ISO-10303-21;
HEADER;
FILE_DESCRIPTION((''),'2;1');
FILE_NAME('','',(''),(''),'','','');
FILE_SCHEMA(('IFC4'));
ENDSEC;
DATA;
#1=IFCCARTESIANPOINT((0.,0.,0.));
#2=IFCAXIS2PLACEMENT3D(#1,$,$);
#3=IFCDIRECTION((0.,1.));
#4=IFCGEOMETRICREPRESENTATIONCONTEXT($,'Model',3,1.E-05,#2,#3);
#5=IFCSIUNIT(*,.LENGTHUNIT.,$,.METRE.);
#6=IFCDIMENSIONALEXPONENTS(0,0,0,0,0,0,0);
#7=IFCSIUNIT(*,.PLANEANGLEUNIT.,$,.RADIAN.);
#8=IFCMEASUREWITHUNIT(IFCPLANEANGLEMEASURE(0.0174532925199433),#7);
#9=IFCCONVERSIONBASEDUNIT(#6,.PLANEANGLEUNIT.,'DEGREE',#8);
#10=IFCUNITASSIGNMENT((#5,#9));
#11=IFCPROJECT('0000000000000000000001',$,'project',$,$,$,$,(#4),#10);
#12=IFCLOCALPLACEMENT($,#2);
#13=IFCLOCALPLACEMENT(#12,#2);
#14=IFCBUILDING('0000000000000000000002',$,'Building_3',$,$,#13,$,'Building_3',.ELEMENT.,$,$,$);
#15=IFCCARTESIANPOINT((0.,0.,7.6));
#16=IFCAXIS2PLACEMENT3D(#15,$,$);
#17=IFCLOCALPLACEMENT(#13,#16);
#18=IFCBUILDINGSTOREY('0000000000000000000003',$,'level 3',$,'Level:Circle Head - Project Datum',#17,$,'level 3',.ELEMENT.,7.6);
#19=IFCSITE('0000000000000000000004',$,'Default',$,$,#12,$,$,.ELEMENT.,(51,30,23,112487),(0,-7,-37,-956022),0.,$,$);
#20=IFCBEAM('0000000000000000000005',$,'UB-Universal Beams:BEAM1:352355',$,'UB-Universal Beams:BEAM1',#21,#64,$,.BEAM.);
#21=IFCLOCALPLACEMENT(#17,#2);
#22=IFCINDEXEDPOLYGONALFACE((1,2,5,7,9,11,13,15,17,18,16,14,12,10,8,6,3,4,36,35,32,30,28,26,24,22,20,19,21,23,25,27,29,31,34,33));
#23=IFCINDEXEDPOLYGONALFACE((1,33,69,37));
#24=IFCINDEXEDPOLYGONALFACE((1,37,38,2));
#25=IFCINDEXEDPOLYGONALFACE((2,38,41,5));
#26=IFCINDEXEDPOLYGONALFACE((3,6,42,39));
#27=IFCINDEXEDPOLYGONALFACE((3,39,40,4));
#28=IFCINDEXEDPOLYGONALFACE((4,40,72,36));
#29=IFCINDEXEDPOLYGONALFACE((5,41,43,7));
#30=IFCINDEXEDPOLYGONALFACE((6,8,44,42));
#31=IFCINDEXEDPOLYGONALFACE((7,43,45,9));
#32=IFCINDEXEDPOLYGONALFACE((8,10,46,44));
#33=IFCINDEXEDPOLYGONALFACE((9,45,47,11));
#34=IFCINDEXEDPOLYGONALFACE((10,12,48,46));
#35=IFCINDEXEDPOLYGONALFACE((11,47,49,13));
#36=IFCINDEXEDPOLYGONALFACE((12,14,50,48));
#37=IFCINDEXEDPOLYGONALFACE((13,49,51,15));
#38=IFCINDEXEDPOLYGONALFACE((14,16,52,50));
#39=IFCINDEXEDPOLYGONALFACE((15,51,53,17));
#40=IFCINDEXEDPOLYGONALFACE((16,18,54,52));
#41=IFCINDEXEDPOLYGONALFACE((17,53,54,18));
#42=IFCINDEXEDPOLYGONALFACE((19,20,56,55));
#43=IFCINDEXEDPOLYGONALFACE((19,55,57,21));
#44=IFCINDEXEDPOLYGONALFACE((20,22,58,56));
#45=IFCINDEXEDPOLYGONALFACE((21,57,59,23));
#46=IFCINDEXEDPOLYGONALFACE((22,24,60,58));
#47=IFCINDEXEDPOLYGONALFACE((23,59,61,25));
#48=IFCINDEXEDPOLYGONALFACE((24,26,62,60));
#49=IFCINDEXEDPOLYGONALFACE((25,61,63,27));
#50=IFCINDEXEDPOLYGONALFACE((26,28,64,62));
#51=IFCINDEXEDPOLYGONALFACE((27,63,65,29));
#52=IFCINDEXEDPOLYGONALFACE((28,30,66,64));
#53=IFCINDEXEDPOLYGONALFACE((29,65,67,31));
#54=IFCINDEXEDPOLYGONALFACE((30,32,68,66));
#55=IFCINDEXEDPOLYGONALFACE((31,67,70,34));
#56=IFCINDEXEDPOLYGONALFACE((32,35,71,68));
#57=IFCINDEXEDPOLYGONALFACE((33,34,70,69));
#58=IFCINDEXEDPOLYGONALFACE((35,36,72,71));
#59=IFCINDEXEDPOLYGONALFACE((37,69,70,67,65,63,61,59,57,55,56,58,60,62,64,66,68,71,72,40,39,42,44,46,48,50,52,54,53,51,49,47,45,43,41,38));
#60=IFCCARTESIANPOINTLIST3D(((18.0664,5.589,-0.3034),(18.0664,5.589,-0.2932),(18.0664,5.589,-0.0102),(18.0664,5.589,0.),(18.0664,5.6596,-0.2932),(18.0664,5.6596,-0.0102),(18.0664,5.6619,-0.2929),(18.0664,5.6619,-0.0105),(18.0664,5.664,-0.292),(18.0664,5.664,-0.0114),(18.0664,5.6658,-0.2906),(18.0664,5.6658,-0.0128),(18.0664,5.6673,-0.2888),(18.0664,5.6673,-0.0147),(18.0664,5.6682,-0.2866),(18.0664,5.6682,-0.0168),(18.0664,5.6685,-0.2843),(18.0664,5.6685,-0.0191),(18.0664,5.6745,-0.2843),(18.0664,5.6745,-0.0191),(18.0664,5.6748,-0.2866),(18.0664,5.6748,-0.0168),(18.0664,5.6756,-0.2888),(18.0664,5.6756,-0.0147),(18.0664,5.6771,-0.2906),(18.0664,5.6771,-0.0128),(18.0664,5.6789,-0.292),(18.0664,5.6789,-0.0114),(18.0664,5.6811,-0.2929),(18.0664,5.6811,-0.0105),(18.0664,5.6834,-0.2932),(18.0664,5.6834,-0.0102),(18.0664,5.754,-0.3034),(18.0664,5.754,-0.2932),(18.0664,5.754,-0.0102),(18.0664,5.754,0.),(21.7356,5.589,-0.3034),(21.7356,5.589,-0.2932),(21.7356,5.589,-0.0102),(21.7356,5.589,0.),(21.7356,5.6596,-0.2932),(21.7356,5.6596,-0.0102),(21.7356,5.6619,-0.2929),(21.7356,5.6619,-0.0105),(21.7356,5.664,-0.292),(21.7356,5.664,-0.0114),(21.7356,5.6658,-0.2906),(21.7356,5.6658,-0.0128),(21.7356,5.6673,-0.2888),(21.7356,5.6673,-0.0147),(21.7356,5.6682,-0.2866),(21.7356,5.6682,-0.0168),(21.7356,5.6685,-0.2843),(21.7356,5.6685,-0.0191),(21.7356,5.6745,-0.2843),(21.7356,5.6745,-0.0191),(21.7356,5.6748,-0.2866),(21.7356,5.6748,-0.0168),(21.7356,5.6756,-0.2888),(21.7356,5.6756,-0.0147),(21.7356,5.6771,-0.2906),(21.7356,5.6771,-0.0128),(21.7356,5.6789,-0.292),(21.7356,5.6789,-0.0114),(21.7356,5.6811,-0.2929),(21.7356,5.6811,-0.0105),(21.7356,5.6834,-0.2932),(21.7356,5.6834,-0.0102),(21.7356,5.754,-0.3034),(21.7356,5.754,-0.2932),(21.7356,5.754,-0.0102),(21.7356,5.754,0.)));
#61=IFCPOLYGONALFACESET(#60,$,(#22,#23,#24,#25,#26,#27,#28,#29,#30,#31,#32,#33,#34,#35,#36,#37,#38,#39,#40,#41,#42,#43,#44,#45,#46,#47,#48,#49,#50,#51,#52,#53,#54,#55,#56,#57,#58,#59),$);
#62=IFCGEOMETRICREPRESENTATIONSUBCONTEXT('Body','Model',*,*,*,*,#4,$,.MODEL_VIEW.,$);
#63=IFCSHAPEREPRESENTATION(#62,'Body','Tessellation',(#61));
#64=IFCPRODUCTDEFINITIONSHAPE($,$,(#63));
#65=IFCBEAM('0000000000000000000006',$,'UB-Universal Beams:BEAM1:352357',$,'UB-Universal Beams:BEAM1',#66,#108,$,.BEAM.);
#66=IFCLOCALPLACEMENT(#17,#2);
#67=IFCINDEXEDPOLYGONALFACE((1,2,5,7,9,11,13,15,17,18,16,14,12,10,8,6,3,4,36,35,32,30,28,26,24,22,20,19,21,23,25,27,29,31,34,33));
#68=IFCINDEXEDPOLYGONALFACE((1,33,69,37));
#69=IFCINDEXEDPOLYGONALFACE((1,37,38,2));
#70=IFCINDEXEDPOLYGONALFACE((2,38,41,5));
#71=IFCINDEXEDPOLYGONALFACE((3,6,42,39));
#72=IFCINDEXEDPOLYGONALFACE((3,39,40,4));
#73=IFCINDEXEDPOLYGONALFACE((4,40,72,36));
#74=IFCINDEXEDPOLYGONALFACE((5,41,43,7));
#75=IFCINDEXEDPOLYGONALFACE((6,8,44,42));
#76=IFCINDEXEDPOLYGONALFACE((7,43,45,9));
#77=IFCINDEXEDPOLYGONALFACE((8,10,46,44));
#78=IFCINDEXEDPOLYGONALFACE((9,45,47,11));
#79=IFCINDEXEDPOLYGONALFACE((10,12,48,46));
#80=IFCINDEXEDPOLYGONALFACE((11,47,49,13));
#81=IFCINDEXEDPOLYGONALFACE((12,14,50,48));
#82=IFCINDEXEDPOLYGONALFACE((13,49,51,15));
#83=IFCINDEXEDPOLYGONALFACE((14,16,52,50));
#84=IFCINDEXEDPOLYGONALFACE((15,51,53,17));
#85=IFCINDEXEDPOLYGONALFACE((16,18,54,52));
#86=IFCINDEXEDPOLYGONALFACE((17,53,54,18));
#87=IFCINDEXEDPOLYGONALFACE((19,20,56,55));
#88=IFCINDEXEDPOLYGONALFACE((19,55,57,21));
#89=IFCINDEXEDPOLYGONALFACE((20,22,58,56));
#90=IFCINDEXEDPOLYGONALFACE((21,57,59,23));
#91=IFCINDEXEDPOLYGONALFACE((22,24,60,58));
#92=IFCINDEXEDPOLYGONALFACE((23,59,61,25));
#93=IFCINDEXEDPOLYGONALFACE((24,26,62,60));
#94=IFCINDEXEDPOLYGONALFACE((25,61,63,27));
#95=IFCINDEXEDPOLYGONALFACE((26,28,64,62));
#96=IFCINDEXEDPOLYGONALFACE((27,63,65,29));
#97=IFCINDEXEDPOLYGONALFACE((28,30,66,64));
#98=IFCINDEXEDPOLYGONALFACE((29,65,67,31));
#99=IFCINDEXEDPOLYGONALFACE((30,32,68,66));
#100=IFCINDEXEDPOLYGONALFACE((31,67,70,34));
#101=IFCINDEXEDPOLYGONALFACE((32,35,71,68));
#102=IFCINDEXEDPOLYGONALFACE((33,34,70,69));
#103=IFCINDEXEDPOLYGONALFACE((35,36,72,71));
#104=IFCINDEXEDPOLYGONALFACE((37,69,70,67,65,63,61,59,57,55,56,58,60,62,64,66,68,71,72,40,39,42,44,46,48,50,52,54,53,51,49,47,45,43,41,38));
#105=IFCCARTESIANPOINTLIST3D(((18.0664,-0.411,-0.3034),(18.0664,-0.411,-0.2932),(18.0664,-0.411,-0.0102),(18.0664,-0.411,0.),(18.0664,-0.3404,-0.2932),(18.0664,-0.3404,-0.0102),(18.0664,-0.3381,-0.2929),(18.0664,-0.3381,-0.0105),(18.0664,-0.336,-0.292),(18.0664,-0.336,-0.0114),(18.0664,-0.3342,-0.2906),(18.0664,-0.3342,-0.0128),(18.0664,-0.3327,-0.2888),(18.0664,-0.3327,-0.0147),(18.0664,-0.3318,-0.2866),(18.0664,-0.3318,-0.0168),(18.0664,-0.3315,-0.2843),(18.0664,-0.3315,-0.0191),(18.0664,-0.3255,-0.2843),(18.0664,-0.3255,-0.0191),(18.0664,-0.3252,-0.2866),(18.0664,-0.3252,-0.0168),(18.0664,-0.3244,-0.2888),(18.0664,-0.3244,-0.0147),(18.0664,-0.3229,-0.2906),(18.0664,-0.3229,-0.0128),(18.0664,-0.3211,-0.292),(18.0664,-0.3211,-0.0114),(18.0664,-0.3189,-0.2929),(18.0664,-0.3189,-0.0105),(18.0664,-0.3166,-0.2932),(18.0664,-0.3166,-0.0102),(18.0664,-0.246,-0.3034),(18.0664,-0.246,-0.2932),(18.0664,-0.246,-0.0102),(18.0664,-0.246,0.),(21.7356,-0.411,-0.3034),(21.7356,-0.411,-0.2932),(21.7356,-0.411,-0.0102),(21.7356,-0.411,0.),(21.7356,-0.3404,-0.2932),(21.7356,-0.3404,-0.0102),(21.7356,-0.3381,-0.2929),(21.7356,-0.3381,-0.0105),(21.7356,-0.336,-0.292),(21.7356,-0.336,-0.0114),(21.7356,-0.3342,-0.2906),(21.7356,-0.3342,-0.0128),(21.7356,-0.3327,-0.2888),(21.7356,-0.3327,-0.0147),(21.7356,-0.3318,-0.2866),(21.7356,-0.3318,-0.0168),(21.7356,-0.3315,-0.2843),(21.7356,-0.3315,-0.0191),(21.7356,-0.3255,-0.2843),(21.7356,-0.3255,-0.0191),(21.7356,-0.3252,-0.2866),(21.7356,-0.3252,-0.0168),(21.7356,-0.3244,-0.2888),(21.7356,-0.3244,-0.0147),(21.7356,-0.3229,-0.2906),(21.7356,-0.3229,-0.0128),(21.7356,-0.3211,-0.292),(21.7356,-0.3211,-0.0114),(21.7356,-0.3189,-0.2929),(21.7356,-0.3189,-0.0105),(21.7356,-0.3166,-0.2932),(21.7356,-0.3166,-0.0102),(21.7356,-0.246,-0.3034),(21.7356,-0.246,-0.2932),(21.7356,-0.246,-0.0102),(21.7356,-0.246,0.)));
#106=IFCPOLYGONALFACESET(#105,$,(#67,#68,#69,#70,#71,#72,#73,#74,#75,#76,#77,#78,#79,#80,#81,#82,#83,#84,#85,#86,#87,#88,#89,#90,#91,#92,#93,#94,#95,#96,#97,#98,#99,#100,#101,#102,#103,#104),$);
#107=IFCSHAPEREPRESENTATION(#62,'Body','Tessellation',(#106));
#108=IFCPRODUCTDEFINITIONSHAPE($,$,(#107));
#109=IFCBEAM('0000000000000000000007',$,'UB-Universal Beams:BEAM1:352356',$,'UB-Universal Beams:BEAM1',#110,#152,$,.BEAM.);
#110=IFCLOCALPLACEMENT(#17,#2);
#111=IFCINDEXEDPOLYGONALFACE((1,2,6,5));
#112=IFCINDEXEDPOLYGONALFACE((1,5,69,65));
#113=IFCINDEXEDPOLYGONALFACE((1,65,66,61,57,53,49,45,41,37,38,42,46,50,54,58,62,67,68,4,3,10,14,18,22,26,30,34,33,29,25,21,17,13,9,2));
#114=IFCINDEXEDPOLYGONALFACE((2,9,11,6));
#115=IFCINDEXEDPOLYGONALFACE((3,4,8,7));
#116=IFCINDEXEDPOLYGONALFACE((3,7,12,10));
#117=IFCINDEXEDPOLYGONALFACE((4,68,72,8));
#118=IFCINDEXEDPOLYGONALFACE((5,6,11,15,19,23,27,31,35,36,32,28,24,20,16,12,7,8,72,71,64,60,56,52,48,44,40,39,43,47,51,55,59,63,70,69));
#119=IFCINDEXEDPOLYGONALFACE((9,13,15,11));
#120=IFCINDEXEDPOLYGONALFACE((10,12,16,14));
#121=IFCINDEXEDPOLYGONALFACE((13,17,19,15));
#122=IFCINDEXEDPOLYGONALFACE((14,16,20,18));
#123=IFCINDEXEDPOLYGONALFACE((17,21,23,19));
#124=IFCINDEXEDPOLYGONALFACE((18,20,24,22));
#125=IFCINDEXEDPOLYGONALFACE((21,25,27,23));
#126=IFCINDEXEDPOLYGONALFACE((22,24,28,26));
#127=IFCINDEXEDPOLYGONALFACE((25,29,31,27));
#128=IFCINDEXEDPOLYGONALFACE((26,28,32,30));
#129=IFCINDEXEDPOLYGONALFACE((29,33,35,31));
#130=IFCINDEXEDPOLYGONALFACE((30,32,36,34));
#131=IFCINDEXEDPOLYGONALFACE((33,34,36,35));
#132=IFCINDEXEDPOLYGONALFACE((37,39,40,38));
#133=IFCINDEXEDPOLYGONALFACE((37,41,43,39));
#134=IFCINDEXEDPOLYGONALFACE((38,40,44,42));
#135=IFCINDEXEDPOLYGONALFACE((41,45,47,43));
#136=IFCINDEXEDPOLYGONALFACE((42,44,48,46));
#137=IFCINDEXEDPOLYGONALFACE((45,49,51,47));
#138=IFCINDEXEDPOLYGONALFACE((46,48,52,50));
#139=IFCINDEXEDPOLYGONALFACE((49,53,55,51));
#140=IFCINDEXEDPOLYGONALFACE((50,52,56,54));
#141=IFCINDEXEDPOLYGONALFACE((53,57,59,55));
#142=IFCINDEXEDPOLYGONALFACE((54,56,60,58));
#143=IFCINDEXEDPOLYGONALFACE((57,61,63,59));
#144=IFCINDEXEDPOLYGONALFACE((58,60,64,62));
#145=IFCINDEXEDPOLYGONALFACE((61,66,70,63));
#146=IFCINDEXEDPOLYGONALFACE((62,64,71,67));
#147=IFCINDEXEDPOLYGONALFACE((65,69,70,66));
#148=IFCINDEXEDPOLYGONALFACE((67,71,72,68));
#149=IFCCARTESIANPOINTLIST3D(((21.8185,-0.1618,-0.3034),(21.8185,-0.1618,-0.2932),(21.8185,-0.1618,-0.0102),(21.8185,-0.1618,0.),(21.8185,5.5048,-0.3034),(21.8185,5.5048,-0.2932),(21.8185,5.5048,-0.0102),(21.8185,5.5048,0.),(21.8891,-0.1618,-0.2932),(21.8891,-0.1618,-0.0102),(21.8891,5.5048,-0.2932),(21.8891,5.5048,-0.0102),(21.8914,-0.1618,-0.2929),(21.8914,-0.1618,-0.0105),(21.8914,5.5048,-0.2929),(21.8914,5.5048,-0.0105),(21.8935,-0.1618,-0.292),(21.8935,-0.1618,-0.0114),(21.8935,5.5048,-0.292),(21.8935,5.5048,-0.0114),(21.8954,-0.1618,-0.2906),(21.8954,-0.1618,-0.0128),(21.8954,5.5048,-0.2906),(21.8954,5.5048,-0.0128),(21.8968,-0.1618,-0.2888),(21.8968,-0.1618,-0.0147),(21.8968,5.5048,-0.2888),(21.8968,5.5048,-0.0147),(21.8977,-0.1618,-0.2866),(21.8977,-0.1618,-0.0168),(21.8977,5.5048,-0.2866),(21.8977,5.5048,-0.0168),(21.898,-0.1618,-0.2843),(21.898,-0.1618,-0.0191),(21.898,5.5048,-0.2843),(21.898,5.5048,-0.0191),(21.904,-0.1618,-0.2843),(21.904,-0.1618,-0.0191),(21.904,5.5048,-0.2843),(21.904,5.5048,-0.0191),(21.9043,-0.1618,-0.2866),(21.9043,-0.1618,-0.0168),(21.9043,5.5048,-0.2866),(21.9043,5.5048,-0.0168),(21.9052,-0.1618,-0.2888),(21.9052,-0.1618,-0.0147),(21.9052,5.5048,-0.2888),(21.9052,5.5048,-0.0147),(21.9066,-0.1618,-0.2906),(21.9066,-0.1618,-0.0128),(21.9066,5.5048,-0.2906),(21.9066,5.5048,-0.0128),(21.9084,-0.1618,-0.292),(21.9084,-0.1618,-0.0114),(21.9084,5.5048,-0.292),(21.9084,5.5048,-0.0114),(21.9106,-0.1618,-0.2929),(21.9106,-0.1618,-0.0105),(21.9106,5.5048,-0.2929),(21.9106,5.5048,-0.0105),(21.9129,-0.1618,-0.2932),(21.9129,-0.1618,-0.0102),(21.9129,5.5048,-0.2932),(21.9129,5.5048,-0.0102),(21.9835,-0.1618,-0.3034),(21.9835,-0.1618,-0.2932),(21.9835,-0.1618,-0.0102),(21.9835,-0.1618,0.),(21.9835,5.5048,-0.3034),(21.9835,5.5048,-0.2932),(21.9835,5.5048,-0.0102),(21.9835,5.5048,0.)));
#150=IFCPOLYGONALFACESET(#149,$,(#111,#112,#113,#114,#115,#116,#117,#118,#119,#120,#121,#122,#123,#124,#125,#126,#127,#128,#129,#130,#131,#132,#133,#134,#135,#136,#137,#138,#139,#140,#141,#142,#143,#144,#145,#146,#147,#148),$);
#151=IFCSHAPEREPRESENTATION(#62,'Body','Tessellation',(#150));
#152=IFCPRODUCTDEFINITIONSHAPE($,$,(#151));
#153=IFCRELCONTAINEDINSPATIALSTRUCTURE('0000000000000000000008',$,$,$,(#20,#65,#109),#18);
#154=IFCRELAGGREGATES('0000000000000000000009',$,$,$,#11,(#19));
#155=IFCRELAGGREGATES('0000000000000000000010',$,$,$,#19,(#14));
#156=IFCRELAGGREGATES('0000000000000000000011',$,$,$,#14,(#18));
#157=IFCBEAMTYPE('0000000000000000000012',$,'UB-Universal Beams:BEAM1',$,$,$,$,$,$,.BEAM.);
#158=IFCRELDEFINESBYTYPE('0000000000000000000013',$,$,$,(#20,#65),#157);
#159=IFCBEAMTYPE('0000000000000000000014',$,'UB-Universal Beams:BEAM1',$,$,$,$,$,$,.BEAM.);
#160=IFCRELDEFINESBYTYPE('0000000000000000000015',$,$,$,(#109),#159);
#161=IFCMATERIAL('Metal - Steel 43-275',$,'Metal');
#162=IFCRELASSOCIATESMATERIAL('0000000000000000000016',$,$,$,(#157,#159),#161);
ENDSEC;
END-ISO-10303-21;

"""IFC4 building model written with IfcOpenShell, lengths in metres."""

from ifc_helpers import new_model, entity, si_unit, converted_unit, direction, frame, frame_2d, origin, place, context, subcontext, project, spatial, polyline, circle_curve, parameter, trimmed, segment, composite_curve, outline, extrude, source, transform, mapped, material, material_profile, profile_set, type_object, type_shapes, element, save


model = new_model("IFC4")

# Units and contexts
model_context = context("Model", 3, precision=1e-05, world=origin(), true_north=direction((0.0, 1.0)))
body_context = subcontext(model_context, "Body", "Model", "MODEL_VIEW")
ifc_project = project(units=[si_unit("LENGTHUNIT", "METRE"), converted_unit("PLANEANGLEUNIT", "DEGREE", entity("IfcPlaneAngleMeasure", 0.0174532925199433), si_unit("PLANEANGLEUNIT", "RADIAN"), dimensions=[0, 0, 0, 0, 0, 0, 0])], contexts=[model_context])

# Site, building, storey
site_placement = place(None, origin())
site = spatial("IfcSite", under=ifc_project, at=site_placement, Name="Default", CompositionType="ELEMENT", RefLatitude=(51, 30, 23, 112487), RefLongitude=(0, -7, -37, -956022), RefElevation=0.0)
building_placement = place(site_placement, origin())
building = spatial("IfcBuilding", under=site, at=building_placement, Name="Building_3", LongName="Building_3", CompositionType="ELEMENT")
storey_placement = place(building_placement, frame((0.0, 0.0, 7.6)))
storey = spatial("IfcBuildingStorey", under=building, at=storey_placement, Name="level 3", ObjectType="Level:Circle Head - Project Datum", LongName="level 3", CompositionType="ELEMENT", Elevation=7.6)

# Beams
ifc_material_1 = material(Name="Metal - Steel 43-275", Category="Metal")
ifc_material_profile = material_profile(ifc_material_1, outline(composite_curve([segment(polyline([(-0.0825, -0.1415), (-0.0825, -0.1517)]), True, "CONTINUOUS"), segment(polyline([(-0.0825, -0.1517), (0.0825, -0.1517)]), True, "CONTINUOUS"), segment(polyline([(0.0825, -0.1517), (0.0825, -0.1415)]), True, "CONTINUOUS"), segment(polyline([(0.0825, -0.1415), (0.0119, -0.1415)]), True, "CONTINUOUS"), segment(trimmed(circle_curve(frame_2d((0.0119, -0.1326), x_axis=(1.0, 0.0)), 0.0089), [parameter(180.0)], [parameter(270.0)], True, "PARAMETER"), False, "CONTINUOUS"), segment(polyline([(0.003, -0.1326), (0.003, 0.1326)]), True, "CONTINUOUS"), segment(trimmed(circle_curve(frame_2d((0.0119, 0.1326), x_axis=(1.0, 0.0)), 0.0089), [parameter(90.0)], [parameter(180.0)], True, "PARAMETER"), False, "CONTINUOUS"), segment(polyline([(0.0119, 0.1415), (0.0825, 0.1415)]), True, "CONTINUOUS"), segment(polyline([(0.0825, 0.1415), (0.0825, 0.1517)]), True, "CONTINUOUS"), segment(polyline([(0.0825, 0.1517), (-0.0825, 0.1517)]), True, "CONTINUOUS"), segment(polyline([(-0.0825, 0.1517), (-0.0825, 0.1415)]), True, "CONTINUOUS"), segment(polyline([(-0.0825, 0.1415), (-0.0119, 0.1415)]), True, "CONTINUOUS"), segment(trimmed(circle_curve(frame_2d((-0.0119, 0.1326), x_axis=(1.0, 0.0)), 0.0089), [parameter(360.0)], [parameter(90.0)], True, "PARAMETER"), False, "CONTINUOUS"), segment(polyline([(-0.003, 0.1326), (-0.003, -0.1326)]), True, "CONTINUOUS"), segment(trimmed(circle_curve(frame_2d((-0.0119, -0.1326), x_axis=(1.0, 0.0)), 0.0089), [parameter(270.0)], [parameter(360.0)], True, "PARAMETER"), False, "CONTINUOUS"), segment(polyline([(-0.0119, -0.1415), (-0.0825, -0.1415)]), True, "CONTINUOUS")], self_intersect=False)), Name="BEAM1")
ifc_profile_set = profile_set([ifc_material_profile], Name="BEAM1")
beam_type_1 = type_object("IfcBeamType", Name="UB-Universal Beams:BEAM1", PredefinedType="BEAM", material=ifc_profile_set)
shared_shape_1 = source(origin(), body_context, "Body", "SweptSolid", [
    extrude(outline(composite_curve([segment(polyline([(-0.0825, -0.1415), (-0.0825, -0.1517)]), True, "CONTINUOUS"), segment(polyline([(-0.0825, -0.1517), (0.0825, -0.1517)]), True, "CONTINUOUS"), segment(polyline([(0.0825, -0.1517), (0.0825, -0.1415)]), True, "CONTINUOUS"), segment(polyline([(0.0825, -0.1415), (0.0119, -0.1415)]), True, "CONTINUOUS"), segment(trimmed(circle_curve(frame_2d((0.0119, -0.1326), x_axis=(0.0, -1.0)), 0.0089), [parameter(270.0)], [parameter(360.0)], True, "PARAMETER"), False, "CONTINUOUS"), segment(polyline([(0.003, -0.1326), (0.003, 0.1326)]), True, "CONTINUOUS"), segment(trimmed(circle_curve(frame_2d((0.0119, 0.1326), x_axis=(-1.0, 0.0)), 0.0089), [parameter(270.0)], [parameter(360.0)], True, "PARAMETER"), False, "CONTINUOUS"), segment(polyline([(0.0119, 0.1415), (0.0825, 0.1415)]), True, "CONTINUOUS"), segment(polyline([(0.0825, 0.1415), (0.0825, 0.1517)]), True, "CONTINUOUS"), segment(polyline([(0.0825, 0.1517), (-0.0825, 0.1517)]), True, "CONTINUOUS"), segment(polyline([(-0.0825, 0.1517), (-0.0825, 0.1415)]), True, "CONTINUOUS"), segment(polyline([(-0.0825, 0.1415), (-0.0119, 0.1415)]), True, "CONTINUOUS"), segment(trimmed(circle_curve(frame_2d((-0.0119, 0.1326), x_axis=(0.0, 1.0)), 0.0089), [parameter(270.0)], [parameter(360.0)], True, "PARAMETER"), False, "CONTINUOUS"), segment(polyline([(-0.003, 0.1326), (-0.003, -0.1326)]), True, "CONTINUOUS"), segment(trimmed(circle_curve(frame_2d((-0.0119, -0.1326), x_axis=(1.0, 0.0)), 0.0089), [parameter(270.0)], [parameter(0.0)], True, "PARAMETER"), False, "CONTINUOUS"), segment(polyline([(-0.0119, -0.1415), (-0.0825, -0.1415)]), True, "CONTINUOUS")], self_intersect=False)), frame((-1.8346, 0.0, 0.0), z_axis=(-1.0, 0.0, 0.0), x_axis=(0.0, -1.0, 0.0)), (0.0, 0.0, -1.0), 3.6692),
])
type_shapes(beam_type_1, [shared_shape_1])
for number, where, name in (
    (1, (19.901, 5.6715, -0.1517), "UB-Universal Beams:BEAM1:352355"),
    (2, (19.901, -0.3285, -0.1517), "UB-Universal Beams:BEAM1:352357"),
):
    element("IfcBeam", number, at=place(storey_placement, frame(where)), inside=storey, type_object=beam_type_1, Name=name, ObjectType="UB-Universal Beams:BEAM1", PredefinedType="BEAM", context=body_context, shape_type="MappedRepresentation", body=[
        mapped(shared_shape_1, transform((0.0, 0.0, 0.0), scale=1.0)),
    ])
beam_type_2 = type_object("IfcBeamType", Name="UB-Universal Beams:BEAM1", PredefinedType="BEAM", material=ifc_profile_set)
shared_shape_2 = source(origin(), body_context, "Body", "SweptSolid", [
    extrude(outline(composite_curve([segment(polyline([(-0.0825, -0.1415), (-0.0825, -0.1517)]), True, "CONTINUOUS"), segment(polyline([(-0.0825, -0.1517), (0.0825, -0.1517)]), True, "CONTINUOUS"), segment(polyline([(0.0825, -0.1517), (0.0825, -0.1415)]), True, "CONTINUOUS"), segment(polyline([(0.0825, -0.1415), (0.0119, -0.1415)]), True, "CONTINUOUS"), segment(trimmed(circle_curve(frame_2d((0.0119, -0.1326), x_axis=(1.0, 0.0)), 0.0089), [parameter(180.0)], [parameter(270.0)], True, "PARAMETER"), False, "CONTINUOUS"), segment(polyline([(0.003, -0.1326), (0.003, 0.1326)]), True, "CONTINUOUS"), segment(trimmed(circle_curve(frame_2d((0.0119, 0.1326), x_axis=(1.0, 0.0)), 0.0089), [parameter(90.0)], [parameter(180.0)], True, "PARAMETER"), False, "CONTINUOUS"), segment(polyline([(0.0119, 0.1415), (0.0825, 0.1415)]), True, "CONTINUOUS"), segment(polyline([(0.0825, 0.1415), (0.0825, 0.1517)]), True, "CONTINUOUS"), segment(polyline([(0.0825, 0.1517), (-0.0825, 0.1517)]), True, "CONTINUOUS"), segment(polyline([(-0.0825, 0.1517), (-0.0825, 0.1415)]), True, "CONTINUOUS"), segment(polyline([(-0.0825, 0.1415), (-0.0119, 0.1415)]), True, "CONTINUOUS"), segment(trimmed(circle_curve(frame_2d((-0.0119, 0.1326), x_axis=(1.0, 0.0)), 0.0089), [parameter(360.0)], [parameter(90.0)], True, "PARAMETER"), False, "CONTINUOUS"), segment(polyline([(-0.003, 0.1326), (-0.003, -0.1326)]), True, "CONTINUOUS"), segment(trimmed(circle_curve(frame_2d((-0.0119, -0.1326), x_axis=(1.0, 0.0)), 0.0089), [parameter(270.0)], [parameter(360.0)], True, "PARAMETER"), False, "CONTINUOUS"), segment(polyline([(-0.0119, -0.1415), (-0.0825, -0.1415)]), True, "CONTINUOUS")], self_intersect=False)), frame((-2.8333, 0.0, 0.0), z_axis=(-1.0, 0.0, 0.0), x_axis=(0.0, -1.0, 0.0)), (0.0, 0.0, -1.0), 5.6666),
])
type_shapes(beam_type_2, [shared_shape_2])
for number, where, z_axis, x_axis, name in (
    (3, (21.901, 2.6715, -0.1517), (0.0, 0.0, 1.0), (0.0, -1.0, 0.0), "UB-Universal Beams:BEAM1:352356"),
):
    element("IfcBeam", number, at=place(storey_placement, frame(where, z_axis=z_axis, x_axis=x_axis)), inside=storey, type_object=beam_type_2, Name=name, ObjectType="UB-Universal Beams:BEAM1", PredefinedType="BEAM", context=body_context, shape_type="MappedRepresentation", body=[
        mapped(shared_shape_2, transform((0.0, 0.0, 0.0), scale=1.0)),
    ])

save(model, "model.ifc")
